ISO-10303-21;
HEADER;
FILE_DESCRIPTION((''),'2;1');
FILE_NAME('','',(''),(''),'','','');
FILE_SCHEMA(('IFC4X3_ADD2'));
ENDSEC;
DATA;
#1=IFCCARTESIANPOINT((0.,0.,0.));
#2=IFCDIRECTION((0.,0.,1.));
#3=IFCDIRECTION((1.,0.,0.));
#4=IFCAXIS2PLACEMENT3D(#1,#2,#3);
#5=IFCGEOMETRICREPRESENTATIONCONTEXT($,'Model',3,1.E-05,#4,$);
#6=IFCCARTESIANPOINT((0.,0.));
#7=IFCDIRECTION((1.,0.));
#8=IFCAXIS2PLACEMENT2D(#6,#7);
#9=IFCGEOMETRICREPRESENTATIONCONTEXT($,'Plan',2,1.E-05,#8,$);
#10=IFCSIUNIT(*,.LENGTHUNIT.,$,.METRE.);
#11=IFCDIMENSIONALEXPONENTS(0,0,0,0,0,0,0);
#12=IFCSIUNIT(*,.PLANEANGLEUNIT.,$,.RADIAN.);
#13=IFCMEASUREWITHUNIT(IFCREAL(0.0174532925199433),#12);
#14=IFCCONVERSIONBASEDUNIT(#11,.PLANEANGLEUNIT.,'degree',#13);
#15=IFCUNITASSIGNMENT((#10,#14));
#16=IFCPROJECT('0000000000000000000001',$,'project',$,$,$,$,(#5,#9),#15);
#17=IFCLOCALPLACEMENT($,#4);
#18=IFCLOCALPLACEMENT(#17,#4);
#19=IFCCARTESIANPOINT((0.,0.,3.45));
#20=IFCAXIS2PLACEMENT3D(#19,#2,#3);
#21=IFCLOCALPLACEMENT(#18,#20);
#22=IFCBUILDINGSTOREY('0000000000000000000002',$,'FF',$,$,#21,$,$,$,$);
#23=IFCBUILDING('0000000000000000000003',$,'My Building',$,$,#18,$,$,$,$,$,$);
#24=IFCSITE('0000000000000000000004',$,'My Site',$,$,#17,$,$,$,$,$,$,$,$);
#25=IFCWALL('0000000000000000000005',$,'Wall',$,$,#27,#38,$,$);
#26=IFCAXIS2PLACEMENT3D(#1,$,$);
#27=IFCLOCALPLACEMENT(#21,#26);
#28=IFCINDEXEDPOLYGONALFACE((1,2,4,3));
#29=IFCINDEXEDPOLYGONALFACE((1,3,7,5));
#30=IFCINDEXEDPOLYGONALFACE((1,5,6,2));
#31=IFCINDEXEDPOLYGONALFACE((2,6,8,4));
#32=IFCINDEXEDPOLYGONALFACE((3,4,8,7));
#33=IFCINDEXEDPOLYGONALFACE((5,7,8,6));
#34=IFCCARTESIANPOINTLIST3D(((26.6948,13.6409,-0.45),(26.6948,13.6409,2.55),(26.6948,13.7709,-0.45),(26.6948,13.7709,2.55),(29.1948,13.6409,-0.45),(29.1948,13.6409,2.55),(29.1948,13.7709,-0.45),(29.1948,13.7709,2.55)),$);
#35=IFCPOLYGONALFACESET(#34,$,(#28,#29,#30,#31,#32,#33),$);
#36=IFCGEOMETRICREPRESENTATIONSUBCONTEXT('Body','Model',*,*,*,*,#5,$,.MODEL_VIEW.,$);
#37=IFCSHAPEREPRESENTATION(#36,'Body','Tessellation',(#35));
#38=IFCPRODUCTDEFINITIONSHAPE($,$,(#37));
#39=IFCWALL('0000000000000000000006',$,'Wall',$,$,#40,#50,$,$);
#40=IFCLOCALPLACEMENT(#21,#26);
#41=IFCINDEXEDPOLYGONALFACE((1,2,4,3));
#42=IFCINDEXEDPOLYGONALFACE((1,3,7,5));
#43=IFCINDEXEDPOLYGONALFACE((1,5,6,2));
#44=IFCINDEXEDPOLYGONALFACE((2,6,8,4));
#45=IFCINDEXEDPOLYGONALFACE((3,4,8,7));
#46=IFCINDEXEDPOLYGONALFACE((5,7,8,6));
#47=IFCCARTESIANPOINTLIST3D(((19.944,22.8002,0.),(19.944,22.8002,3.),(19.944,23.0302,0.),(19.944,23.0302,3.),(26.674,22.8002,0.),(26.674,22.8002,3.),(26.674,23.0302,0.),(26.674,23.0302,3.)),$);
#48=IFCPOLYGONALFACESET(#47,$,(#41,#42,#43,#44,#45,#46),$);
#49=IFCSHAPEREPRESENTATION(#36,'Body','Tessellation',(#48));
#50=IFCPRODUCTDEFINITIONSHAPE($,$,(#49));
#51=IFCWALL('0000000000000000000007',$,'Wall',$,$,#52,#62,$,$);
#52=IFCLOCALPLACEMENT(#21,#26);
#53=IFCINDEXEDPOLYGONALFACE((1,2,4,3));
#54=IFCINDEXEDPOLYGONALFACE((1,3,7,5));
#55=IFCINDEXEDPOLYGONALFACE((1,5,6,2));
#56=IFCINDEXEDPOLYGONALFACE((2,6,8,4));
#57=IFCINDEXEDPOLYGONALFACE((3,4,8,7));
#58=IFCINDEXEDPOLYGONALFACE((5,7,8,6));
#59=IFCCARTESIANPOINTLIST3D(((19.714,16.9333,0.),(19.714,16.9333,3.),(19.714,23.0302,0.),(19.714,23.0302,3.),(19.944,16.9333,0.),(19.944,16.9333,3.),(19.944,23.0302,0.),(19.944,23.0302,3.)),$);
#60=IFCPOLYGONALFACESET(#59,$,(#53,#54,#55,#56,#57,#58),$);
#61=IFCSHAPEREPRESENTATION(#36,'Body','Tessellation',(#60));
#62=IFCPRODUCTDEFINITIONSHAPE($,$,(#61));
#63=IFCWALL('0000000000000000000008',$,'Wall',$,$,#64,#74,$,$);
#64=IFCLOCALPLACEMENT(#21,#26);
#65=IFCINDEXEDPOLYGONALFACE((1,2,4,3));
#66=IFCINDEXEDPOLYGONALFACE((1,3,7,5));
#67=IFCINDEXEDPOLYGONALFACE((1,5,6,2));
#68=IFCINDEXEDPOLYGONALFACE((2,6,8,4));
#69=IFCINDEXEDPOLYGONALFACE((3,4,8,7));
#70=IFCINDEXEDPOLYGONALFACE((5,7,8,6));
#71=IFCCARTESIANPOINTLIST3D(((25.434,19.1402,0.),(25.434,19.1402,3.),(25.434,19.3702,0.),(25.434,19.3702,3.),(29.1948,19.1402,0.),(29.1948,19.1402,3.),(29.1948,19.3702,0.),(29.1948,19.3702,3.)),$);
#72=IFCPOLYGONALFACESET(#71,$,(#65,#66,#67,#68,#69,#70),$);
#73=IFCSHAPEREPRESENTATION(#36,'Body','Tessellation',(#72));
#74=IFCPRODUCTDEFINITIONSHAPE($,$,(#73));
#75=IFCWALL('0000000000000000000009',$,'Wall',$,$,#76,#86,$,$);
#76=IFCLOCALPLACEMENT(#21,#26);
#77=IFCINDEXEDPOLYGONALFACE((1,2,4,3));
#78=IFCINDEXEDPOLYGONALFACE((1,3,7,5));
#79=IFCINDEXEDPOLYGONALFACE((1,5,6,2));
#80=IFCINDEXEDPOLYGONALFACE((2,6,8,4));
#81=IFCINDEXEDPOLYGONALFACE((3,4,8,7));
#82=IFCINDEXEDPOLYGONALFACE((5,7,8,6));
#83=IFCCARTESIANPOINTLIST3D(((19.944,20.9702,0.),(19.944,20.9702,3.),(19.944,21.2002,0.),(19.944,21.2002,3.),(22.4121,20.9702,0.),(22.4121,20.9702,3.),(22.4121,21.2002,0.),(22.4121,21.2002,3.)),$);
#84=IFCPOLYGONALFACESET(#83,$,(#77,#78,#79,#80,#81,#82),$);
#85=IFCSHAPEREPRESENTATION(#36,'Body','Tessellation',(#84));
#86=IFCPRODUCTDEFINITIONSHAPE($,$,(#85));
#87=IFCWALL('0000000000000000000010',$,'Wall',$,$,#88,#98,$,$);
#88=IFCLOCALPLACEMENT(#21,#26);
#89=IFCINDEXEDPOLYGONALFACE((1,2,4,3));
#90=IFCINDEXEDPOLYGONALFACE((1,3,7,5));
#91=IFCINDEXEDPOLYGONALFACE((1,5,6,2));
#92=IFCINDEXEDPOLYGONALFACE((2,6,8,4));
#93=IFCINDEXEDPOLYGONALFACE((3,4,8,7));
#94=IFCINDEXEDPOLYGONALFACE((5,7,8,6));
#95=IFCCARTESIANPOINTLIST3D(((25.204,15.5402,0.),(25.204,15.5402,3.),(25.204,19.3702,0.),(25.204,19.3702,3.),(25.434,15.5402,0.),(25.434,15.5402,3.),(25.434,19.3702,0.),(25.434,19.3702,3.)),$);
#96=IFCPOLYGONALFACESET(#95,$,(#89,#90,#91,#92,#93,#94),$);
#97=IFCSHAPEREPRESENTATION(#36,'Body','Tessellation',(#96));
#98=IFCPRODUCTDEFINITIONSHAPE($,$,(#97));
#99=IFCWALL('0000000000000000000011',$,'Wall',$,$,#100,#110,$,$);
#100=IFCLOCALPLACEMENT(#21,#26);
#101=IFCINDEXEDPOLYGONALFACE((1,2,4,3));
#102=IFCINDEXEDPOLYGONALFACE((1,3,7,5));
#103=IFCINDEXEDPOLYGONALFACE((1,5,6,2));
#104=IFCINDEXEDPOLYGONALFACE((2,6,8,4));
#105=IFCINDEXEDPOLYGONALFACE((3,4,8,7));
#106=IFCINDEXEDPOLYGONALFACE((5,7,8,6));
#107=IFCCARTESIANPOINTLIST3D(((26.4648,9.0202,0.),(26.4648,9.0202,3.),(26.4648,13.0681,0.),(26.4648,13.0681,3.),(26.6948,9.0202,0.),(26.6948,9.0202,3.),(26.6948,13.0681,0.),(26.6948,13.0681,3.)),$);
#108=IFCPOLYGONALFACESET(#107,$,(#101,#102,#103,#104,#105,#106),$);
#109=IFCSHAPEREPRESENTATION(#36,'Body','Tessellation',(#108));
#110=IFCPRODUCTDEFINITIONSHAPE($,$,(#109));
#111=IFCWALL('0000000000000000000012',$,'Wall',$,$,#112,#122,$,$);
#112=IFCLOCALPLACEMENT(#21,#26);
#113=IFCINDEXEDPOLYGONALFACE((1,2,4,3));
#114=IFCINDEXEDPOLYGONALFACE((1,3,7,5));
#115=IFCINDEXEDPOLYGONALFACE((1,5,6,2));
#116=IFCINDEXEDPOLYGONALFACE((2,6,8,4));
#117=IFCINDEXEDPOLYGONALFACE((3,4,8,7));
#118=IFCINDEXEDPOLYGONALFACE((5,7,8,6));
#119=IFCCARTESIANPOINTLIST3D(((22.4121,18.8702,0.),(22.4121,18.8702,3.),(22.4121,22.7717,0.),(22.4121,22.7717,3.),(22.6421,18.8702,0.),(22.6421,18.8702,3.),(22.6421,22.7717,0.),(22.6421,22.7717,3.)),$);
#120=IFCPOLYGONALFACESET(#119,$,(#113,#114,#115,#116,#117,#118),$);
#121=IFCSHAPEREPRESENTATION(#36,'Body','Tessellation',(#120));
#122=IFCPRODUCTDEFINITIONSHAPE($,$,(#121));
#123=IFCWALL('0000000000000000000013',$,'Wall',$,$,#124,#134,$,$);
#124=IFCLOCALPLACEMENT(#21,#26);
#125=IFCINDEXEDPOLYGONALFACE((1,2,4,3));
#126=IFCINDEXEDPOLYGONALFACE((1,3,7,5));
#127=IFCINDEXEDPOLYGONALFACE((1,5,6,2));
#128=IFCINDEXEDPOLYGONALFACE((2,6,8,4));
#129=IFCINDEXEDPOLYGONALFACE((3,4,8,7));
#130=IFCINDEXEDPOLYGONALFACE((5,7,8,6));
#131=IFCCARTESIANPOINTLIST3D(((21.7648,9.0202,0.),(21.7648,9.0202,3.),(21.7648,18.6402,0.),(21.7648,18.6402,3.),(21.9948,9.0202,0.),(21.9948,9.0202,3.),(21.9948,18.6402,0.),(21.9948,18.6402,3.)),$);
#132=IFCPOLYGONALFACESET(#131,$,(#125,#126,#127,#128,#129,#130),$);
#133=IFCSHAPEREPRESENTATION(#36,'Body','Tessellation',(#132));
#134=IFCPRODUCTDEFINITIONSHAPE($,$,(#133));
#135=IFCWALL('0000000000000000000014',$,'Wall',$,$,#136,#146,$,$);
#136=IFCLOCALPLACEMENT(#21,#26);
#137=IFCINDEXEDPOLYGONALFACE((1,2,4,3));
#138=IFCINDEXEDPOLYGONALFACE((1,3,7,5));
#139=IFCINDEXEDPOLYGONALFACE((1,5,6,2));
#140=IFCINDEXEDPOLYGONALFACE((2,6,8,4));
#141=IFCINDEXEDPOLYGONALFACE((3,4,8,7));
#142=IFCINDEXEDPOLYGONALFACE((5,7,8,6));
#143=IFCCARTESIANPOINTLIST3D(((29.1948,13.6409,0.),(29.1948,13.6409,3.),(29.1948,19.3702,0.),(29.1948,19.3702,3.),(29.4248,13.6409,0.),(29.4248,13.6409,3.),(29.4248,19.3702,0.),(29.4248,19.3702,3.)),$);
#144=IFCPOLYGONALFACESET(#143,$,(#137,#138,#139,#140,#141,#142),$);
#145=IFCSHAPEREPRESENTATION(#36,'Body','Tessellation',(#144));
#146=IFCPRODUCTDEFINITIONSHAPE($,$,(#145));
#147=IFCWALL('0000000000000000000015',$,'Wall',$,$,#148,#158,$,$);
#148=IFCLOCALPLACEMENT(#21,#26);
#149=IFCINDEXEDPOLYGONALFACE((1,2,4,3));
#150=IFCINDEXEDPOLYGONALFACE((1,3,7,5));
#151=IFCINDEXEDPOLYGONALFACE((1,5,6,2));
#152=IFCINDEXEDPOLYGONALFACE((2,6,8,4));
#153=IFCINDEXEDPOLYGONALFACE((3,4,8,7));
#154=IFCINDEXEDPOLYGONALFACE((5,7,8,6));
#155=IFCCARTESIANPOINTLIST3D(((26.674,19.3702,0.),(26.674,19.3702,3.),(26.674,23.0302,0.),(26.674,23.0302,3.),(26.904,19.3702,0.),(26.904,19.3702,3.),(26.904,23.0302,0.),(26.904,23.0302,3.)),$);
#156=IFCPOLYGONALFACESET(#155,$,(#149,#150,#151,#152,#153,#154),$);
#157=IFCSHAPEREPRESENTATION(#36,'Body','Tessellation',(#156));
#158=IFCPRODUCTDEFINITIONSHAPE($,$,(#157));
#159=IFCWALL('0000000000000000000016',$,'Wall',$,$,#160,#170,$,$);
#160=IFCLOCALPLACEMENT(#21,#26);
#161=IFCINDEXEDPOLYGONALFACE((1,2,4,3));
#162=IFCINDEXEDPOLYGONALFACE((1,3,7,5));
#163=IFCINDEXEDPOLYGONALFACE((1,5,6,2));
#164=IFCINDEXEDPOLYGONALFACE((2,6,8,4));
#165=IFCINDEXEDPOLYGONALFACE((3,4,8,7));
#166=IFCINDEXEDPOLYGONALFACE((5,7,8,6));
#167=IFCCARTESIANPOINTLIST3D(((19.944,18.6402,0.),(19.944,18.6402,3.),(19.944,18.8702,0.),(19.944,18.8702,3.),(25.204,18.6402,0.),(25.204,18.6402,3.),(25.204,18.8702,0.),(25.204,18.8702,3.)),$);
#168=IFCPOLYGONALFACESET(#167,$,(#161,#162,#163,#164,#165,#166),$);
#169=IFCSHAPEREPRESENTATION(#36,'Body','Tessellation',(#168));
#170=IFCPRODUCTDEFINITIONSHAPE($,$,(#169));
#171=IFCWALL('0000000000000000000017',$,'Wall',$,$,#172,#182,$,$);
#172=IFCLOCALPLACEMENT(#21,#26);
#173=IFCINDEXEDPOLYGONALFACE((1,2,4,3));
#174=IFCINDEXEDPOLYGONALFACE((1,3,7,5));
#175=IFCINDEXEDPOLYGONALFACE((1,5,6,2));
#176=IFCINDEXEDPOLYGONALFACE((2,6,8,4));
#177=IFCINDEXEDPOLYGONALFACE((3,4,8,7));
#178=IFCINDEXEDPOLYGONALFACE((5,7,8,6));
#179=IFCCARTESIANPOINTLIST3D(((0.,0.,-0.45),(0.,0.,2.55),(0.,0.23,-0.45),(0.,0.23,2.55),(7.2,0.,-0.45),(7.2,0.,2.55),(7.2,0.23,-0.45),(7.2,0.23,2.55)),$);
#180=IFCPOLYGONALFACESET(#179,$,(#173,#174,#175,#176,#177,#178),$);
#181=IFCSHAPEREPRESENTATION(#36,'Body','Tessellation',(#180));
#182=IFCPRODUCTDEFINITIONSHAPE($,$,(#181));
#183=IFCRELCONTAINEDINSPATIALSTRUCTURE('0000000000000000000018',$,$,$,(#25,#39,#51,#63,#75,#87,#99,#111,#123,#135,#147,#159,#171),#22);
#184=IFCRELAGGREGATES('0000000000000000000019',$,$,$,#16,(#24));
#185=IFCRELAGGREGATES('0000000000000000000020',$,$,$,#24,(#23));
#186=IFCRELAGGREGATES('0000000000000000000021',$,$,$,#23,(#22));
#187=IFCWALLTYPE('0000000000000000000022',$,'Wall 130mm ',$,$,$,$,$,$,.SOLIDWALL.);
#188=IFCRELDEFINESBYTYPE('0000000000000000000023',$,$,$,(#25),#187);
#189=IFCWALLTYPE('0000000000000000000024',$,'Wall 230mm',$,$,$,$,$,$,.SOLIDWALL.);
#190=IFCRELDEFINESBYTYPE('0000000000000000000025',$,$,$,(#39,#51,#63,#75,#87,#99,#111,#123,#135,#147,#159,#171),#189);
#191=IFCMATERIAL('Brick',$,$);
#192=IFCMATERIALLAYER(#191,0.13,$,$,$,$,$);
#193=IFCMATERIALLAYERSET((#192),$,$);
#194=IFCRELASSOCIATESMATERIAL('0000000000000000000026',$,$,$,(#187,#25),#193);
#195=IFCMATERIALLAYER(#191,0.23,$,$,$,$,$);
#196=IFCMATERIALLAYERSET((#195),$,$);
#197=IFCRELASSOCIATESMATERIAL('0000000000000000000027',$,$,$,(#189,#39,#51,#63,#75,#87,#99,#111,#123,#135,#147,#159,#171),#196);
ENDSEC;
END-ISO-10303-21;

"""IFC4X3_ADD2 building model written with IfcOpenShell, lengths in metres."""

from ifc_helpers import new_model, entity, si_unit, converted_unit, frame, origin_with_axes, origin_2d_with_axis, place, context, subcontext, project, spatial, indexed_curve, outline, extrude, material, layer, layer_set, layer_usage, type_object, element, save


model = new_model("IFC4X3_ADD2")

# Units and contexts
model_context = context("Model", 3, precision=1e-05, world=origin_with_axes())
plan_context = context("Plan", 2, precision=1e-05, world=origin_2d_with_axis())
body_context = subcontext(model_context, "Body", "Model", "MODEL_VIEW")
ifc_project = project(units=[si_unit("LENGTHUNIT", "METRE"), converted_unit("PLANEANGLEUNIT", "degree", entity("IfcReal", 0.0174532925199433), si_unit("PLANEANGLEUNIT", "RADIAN"), dimensions=[0, 0, 0, 0, 0, 0, 0])], contexts=[model_context, plan_context])

# Site, building, storey
site_placement = place(None, origin_with_axes())
site = spatial("IfcSite", under=ifc_project, at=site_placement, Name="My Site")
building_placement = place(site_placement, origin_with_axes())
building = spatial("IfcBuilding", under=site, at=building_placement, Name="My Building")
storey_placement = place(building_placement, frame((0.0, 0.0, 3.45), z_axis=(0.0, 0.0, 1.0), x_axis=(1.0, 0.0, 0.0)))
storey = spatial("IfcBuildingStorey", under=building, at=storey_placement, Name="FF")

# Walls
ifc_material = material(Name="Brick")
ifc_layer_1 = layer(ifc_material, 0.13)
ifc_layer_set_1 = layer_set([ifc_layer_1])
ifc_layer_usage_1 = layer_usage(ifc_layer_set_1, "AXIS2", "POSITIVE", 0.0)
wall_type_1 = type_object("IfcWallType", Name="Wall 130mm ", PredefinedType="SOLIDWALL", material=ifc_layer_set_1)
wall_1_placement = place(storey_placement, frame((29.1948, 13.7709, -0.45), z_axis=(0.0, 0.0, 1.0), x_axis=(-1.0, 0.0, 0.0)))
element("IfcWall", 1, at=wall_1_placement, inside=storey, type_object=wall_type_1, material=ifc_layer_usage_1, Name="Wall", context=body_context, shape_type="SweptSolid", body=[
    extrude(outline(indexed_curve([(0.0, 0.0), (0.0, 0.13), (2.5, 0.13), (2.5, 0.0), (0.0, 0.0)], self_intersect=False)), origin_with_axes(), (0.0, 0.0, 1.0), 3.0),
])
ifc_layer_2 = layer(ifc_material, 0.23)
ifc_layer_set_2 = layer_set([ifc_layer_2])
ifc_layer_usage_2 = layer_usage(ifc_layer_set_2, "AXIS2", "POSITIVE", 0.0)
wall_type_2 = type_object("IfcWallType", Name="Wall 230mm", PredefinedType="SOLIDWALL", material=ifc_layer_set_2)
wall_2_placement = place(storey_placement, frame((26.674, 23.0302, 0.0), z_axis=(0.0, 0.0, 1.0), x_axis=(-1.0, 0.0, 0.0)))
element("IfcWall", 2, at=wall_2_placement, inside=storey, type_object=wall_type_2, material=ifc_layer_usage_2, Name="Wall", context=body_context, shape_type="SweptSolid", body=[
    extrude(outline(indexed_curve([(0.0, 0.0), (0.0, 0.23), (6.73, 0.23), (6.73, 0.0), (0.0, 0.0)], self_intersect=False)), origin_with_axes(), (0.0, 0.0, 1.0), 3.0),
])
ifc_layer_usage_3 = layer_usage(ifc_layer_set_2, "AXIS2", "POSITIVE", 0.0)
wall_3_placement = place(storey_placement, frame((19.944, 16.9333, 0.0), z_axis=(0.0, 0.0, 1.0), x_axis=(0.000001, 1.0, 0.0)))
element("IfcWall", 3, at=wall_3_placement, inside=storey, type_object=wall_type_2, material=ifc_layer_usage_3, Name="Wall", context=body_context, shape_type="SweptSolid", body=[
    extrude(outline(indexed_curve([(0.0, 0.0), (0.0, 0.23), (6.0969, 0.23), (6.0969, 0.0), (0.0, 0.0)], self_intersect=False)), origin_with_axes(), (0.0, 0.0, 1.0), 3.0),
])
ifc_layer_usage_4 = layer_usage(ifc_layer_set_2, "AXIS2", "POSITIVE", 0.0)
wall_4_placement = place(storey_placement, frame((29.1948, 19.3702, 0.0), z_axis=(0.0, 0.0, 1.0), x_axis=(-1.0, 0.0, 0.0)))
element("IfcWall", 4, at=wall_4_placement, inside=storey, type_object=wall_type_2, material=ifc_layer_usage_4, Name="Wall", context=body_context, shape_type="SweptSolid", body=[
    extrude(outline(indexed_curve([(0.0, 0.0), (0.0, 0.23), (3.7608, 0.23), (3.7608, 0.0), (0.0, 0.0)], self_intersect=False)), origin_with_axes(), (0.0, 0.0, 1.0), 3.0),
])
ifc_layer_usage_5 = layer_usage(ifc_layer_set_2, "AXIS2", "POSITIVE", 0.0)
wall_5_placement = place(storey_placement, frame((22.4121, 21.2002, 0.0), z_axis=(0.0, 0.0, 1.0), x_axis=(-1.0, 0.0, 0.0)))
element("IfcWall", 5, at=wall_5_placement, inside=storey, type_object=wall_type_2, material=ifc_layer_usage_5, Name="Wall", context=body_context, shape_type="SweptSolid", body=[
    extrude(outline(indexed_curve([(0.0, 0.0), (0.0, 0.23), (2.4681, 0.23), (2.4681, 0.0), (0.0, 0.0)], self_intersect=False)), origin_with_axes(), (0.0, 0.0, 1.0), 3.0),
])
ifc_layer_usage_6 = layer_usage(ifc_layer_set_2, "AXIS2", "POSITIVE", 0.0)
wall_6_placement = place(storey_placement, frame((25.434, 15.5402, 0.0), z_axis=(0.0, 0.0, 1.0), x_axis=(0.000001, 1.0, 0.0)))
element("IfcWall", 6, at=wall_6_placement, inside=storey, type_object=wall_type_2, material=ifc_layer_usage_6, Name="Wall", context=body_context, shape_type="SweptSolid", body=[
    extrude(outline(indexed_curve([(0.0, 0.0), (0.0, 0.23), (3.83, 0.23), (3.83, 0.0), (0.0, 0.0)], self_intersect=False)), origin_with_axes(), (0.0, 0.0, 1.0), 3.0),
])
ifc_layer_usage_7 = layer_usage(ifc_layer_set_2, "AXIS2", "POSITIVE", 0.0)
wall_7_placement = place(storey_placement, frame((26.6948, 9.0202, 0.0), z_axis=(0.0, 0.0, 1.0), x_axis=(0.000001, 1.0, 0.0)))
element("IfcWall", 7, at=wall_7_placement, inside=storey, type_object=wall_type_2, material=ifc_layer_usage_7, Name="Wall", context=body_context, shape_type="SweptSolid", body=[
    extrude(outline(indexed_curve([(0.0, 0.0), (0.0, 0.23), (4.0479, 0.23), (4.0479, 0.0), (0.0, 0.0)], self_intersect=False)), origin_with_axes(), (0.0, 0.0, 1.0), 3.0),
])
ifc_layer_usage_8 = layer_usage(ifc_layer_set_2, "AXIS2", "POSITIVE", 0.0)
wall_8_placement = place(storey_placement, frame((22.6421, 18.8702, 0.0), z_axis=(0.0, 0.0, 1.0), x_axis=(0.000001, 1.0, 0.0)))
element("IfcWall", 8, at=wall_8_placement, inside=storey, type_object=wall_type_2, material=ifc_layer_usage_8, Name="Wall", context=body_context, shape_type="SweptSolid", body=[
    extrude(outline(indexed_curve([(0.0, 0.0), (0.0, 0.23), (3.9015, 0.23), (3.9015, 0.0), (0.0, 0.0)], self_intersect=False)), origin_with_axes(), (0.0, 0.0, 1.0), 3.0),
])
ifc_layer_usage_9 = layer_usage(ifc_layer_set_2, "AXIS2", "POSITIVE", 0.0)
wall_9_placement = place(storey_placement, frame((21.9948, 9.0202, 0.0), z_axis=(0.0, 0.0, 1.0), x_axis=(0.000001, 1.0, 0.0)))
element("IfcWall", 9, at=wall_9_placement, inside=storey, type_object=wall_type_2, material=ifc_layer_usage_9, Name="Wall", context=body_context, shape_type="SweptSolid", body=[
    extrude(outline(indexed_curve([(0.0, 0.0), (0.0, 0.23), (9.62, 0.23), (9.62, 0.0), (0.0, 0.0)], self_intersect=False)), origin_with_axes(), (0.0, 0.0, 1.0), 3.0),
])
ifc_layer_usage_10 = layer_usage(ifc_layer_set_2, "AXIS2", "POSITIVE", 0.0)
wall_10_placement = place(storey_placement, frame((29.4248, 13.6409, 0.0), z_axis=(0.0, 0.0, 1.0), x_axis=(0.000001, 1.0, 0.0)))
element("IfcWall", 10, at=wall_10_placement, inside=storey, type_object=wall_type_2, material=ifc_layer_usage_10, Name="Wall", context=body_context, shape_type="SweptSolid", body=[
    extrude(outline(indexed_curve([(0.0, 0.0), (0.0, 0.23), (5.7293, 0.23), (5.7293, 0.0), (0.0, 0.0)], self_intersect=False)), origin_with_axes(), (0.0, 0.0, 1.0), 3.0),
])
ifc_layer_usage_11 = layer_usage(ifc_layer_set_2, "AXIS2", "POSITIVE", 0.0)
wall_11_placement = place(storey_placement, frame((26.904, 19.3702, 0.0), z_axis=(0.0, 0.0, 1.0), x_axis=(0.000001, 1.0, 0.0)))
element("IfcWall", 11, at=wall_11_placement, inside=storey, type_object=wall_type_2, material=ifc_layer_usage_11, Name="Wall", context=body_context, shape_type="SweptSolid", body=[
    extrude(outline(indexed_curve([(0.0, 0.0), (0.0, 0.23), (3.66, 0.23), (3.66, 0.0), (0.0, 0.0)], self_intersect=False)), origin_with_axes(), (0.0, 0.0, 1.0), 3.0),
])
ifc_layer_usage_12 = layer_usage(ifc_layer_set_2, "AXIS2", "POSITIVE", 0.0)
wall_12_placement = place(storey_placement, frame((25.204, 18.8702, 0.0), z_axis=(0.0, 0.0, 1.0), x_axis=(-1.0, 0.0, 0.0)))
element("IfcWall", 12, at=wall_12_placement, inside=storey, type_object=wall_type_2, material=ifc_layer_usage_12, Name="Wall", context=body_context, shape_type="SweptSolid", body=[
    extrude(outline(indexed_curve([(0.0, 0.0), (0.0, 0.23), (5.26, 0.23), (5.26, 0.0), (0.0, 0.0)], self_intersect=False)), origin_with_axes(), (0.0, 0.0, 1.0), 3.0),
])
ifc_layer_usage_13 = layer_usage(ifc_layer_set_2, "AXIS2", "POSITIVE", 0.0)
wall_13_placement = place(storey_placement, frame((0.0, 0.0, -0.45), z_axis=(0.0, 0.0, 1.0), x_axis=(1.0, 0.0, 0.0)))
element("IfcWall", 13, at=wall_13_placement, inside=storey, type_object=wall_type_2, material=ifc_layer_usage_13, Name="Wall", context=body_context, shape_type="SweptSolid", body=[
    extrude(outline(indexed_curve([(0.0, 0.0), (0.0, 0.23), (7.2, 0.23), (7.2, 0.0), (0.0, 0.0)], self_intersect=False)), origin_with_axes(), (0.0, 0.0, 1.0), 3.0),
])

save(model, "model.ifc")
